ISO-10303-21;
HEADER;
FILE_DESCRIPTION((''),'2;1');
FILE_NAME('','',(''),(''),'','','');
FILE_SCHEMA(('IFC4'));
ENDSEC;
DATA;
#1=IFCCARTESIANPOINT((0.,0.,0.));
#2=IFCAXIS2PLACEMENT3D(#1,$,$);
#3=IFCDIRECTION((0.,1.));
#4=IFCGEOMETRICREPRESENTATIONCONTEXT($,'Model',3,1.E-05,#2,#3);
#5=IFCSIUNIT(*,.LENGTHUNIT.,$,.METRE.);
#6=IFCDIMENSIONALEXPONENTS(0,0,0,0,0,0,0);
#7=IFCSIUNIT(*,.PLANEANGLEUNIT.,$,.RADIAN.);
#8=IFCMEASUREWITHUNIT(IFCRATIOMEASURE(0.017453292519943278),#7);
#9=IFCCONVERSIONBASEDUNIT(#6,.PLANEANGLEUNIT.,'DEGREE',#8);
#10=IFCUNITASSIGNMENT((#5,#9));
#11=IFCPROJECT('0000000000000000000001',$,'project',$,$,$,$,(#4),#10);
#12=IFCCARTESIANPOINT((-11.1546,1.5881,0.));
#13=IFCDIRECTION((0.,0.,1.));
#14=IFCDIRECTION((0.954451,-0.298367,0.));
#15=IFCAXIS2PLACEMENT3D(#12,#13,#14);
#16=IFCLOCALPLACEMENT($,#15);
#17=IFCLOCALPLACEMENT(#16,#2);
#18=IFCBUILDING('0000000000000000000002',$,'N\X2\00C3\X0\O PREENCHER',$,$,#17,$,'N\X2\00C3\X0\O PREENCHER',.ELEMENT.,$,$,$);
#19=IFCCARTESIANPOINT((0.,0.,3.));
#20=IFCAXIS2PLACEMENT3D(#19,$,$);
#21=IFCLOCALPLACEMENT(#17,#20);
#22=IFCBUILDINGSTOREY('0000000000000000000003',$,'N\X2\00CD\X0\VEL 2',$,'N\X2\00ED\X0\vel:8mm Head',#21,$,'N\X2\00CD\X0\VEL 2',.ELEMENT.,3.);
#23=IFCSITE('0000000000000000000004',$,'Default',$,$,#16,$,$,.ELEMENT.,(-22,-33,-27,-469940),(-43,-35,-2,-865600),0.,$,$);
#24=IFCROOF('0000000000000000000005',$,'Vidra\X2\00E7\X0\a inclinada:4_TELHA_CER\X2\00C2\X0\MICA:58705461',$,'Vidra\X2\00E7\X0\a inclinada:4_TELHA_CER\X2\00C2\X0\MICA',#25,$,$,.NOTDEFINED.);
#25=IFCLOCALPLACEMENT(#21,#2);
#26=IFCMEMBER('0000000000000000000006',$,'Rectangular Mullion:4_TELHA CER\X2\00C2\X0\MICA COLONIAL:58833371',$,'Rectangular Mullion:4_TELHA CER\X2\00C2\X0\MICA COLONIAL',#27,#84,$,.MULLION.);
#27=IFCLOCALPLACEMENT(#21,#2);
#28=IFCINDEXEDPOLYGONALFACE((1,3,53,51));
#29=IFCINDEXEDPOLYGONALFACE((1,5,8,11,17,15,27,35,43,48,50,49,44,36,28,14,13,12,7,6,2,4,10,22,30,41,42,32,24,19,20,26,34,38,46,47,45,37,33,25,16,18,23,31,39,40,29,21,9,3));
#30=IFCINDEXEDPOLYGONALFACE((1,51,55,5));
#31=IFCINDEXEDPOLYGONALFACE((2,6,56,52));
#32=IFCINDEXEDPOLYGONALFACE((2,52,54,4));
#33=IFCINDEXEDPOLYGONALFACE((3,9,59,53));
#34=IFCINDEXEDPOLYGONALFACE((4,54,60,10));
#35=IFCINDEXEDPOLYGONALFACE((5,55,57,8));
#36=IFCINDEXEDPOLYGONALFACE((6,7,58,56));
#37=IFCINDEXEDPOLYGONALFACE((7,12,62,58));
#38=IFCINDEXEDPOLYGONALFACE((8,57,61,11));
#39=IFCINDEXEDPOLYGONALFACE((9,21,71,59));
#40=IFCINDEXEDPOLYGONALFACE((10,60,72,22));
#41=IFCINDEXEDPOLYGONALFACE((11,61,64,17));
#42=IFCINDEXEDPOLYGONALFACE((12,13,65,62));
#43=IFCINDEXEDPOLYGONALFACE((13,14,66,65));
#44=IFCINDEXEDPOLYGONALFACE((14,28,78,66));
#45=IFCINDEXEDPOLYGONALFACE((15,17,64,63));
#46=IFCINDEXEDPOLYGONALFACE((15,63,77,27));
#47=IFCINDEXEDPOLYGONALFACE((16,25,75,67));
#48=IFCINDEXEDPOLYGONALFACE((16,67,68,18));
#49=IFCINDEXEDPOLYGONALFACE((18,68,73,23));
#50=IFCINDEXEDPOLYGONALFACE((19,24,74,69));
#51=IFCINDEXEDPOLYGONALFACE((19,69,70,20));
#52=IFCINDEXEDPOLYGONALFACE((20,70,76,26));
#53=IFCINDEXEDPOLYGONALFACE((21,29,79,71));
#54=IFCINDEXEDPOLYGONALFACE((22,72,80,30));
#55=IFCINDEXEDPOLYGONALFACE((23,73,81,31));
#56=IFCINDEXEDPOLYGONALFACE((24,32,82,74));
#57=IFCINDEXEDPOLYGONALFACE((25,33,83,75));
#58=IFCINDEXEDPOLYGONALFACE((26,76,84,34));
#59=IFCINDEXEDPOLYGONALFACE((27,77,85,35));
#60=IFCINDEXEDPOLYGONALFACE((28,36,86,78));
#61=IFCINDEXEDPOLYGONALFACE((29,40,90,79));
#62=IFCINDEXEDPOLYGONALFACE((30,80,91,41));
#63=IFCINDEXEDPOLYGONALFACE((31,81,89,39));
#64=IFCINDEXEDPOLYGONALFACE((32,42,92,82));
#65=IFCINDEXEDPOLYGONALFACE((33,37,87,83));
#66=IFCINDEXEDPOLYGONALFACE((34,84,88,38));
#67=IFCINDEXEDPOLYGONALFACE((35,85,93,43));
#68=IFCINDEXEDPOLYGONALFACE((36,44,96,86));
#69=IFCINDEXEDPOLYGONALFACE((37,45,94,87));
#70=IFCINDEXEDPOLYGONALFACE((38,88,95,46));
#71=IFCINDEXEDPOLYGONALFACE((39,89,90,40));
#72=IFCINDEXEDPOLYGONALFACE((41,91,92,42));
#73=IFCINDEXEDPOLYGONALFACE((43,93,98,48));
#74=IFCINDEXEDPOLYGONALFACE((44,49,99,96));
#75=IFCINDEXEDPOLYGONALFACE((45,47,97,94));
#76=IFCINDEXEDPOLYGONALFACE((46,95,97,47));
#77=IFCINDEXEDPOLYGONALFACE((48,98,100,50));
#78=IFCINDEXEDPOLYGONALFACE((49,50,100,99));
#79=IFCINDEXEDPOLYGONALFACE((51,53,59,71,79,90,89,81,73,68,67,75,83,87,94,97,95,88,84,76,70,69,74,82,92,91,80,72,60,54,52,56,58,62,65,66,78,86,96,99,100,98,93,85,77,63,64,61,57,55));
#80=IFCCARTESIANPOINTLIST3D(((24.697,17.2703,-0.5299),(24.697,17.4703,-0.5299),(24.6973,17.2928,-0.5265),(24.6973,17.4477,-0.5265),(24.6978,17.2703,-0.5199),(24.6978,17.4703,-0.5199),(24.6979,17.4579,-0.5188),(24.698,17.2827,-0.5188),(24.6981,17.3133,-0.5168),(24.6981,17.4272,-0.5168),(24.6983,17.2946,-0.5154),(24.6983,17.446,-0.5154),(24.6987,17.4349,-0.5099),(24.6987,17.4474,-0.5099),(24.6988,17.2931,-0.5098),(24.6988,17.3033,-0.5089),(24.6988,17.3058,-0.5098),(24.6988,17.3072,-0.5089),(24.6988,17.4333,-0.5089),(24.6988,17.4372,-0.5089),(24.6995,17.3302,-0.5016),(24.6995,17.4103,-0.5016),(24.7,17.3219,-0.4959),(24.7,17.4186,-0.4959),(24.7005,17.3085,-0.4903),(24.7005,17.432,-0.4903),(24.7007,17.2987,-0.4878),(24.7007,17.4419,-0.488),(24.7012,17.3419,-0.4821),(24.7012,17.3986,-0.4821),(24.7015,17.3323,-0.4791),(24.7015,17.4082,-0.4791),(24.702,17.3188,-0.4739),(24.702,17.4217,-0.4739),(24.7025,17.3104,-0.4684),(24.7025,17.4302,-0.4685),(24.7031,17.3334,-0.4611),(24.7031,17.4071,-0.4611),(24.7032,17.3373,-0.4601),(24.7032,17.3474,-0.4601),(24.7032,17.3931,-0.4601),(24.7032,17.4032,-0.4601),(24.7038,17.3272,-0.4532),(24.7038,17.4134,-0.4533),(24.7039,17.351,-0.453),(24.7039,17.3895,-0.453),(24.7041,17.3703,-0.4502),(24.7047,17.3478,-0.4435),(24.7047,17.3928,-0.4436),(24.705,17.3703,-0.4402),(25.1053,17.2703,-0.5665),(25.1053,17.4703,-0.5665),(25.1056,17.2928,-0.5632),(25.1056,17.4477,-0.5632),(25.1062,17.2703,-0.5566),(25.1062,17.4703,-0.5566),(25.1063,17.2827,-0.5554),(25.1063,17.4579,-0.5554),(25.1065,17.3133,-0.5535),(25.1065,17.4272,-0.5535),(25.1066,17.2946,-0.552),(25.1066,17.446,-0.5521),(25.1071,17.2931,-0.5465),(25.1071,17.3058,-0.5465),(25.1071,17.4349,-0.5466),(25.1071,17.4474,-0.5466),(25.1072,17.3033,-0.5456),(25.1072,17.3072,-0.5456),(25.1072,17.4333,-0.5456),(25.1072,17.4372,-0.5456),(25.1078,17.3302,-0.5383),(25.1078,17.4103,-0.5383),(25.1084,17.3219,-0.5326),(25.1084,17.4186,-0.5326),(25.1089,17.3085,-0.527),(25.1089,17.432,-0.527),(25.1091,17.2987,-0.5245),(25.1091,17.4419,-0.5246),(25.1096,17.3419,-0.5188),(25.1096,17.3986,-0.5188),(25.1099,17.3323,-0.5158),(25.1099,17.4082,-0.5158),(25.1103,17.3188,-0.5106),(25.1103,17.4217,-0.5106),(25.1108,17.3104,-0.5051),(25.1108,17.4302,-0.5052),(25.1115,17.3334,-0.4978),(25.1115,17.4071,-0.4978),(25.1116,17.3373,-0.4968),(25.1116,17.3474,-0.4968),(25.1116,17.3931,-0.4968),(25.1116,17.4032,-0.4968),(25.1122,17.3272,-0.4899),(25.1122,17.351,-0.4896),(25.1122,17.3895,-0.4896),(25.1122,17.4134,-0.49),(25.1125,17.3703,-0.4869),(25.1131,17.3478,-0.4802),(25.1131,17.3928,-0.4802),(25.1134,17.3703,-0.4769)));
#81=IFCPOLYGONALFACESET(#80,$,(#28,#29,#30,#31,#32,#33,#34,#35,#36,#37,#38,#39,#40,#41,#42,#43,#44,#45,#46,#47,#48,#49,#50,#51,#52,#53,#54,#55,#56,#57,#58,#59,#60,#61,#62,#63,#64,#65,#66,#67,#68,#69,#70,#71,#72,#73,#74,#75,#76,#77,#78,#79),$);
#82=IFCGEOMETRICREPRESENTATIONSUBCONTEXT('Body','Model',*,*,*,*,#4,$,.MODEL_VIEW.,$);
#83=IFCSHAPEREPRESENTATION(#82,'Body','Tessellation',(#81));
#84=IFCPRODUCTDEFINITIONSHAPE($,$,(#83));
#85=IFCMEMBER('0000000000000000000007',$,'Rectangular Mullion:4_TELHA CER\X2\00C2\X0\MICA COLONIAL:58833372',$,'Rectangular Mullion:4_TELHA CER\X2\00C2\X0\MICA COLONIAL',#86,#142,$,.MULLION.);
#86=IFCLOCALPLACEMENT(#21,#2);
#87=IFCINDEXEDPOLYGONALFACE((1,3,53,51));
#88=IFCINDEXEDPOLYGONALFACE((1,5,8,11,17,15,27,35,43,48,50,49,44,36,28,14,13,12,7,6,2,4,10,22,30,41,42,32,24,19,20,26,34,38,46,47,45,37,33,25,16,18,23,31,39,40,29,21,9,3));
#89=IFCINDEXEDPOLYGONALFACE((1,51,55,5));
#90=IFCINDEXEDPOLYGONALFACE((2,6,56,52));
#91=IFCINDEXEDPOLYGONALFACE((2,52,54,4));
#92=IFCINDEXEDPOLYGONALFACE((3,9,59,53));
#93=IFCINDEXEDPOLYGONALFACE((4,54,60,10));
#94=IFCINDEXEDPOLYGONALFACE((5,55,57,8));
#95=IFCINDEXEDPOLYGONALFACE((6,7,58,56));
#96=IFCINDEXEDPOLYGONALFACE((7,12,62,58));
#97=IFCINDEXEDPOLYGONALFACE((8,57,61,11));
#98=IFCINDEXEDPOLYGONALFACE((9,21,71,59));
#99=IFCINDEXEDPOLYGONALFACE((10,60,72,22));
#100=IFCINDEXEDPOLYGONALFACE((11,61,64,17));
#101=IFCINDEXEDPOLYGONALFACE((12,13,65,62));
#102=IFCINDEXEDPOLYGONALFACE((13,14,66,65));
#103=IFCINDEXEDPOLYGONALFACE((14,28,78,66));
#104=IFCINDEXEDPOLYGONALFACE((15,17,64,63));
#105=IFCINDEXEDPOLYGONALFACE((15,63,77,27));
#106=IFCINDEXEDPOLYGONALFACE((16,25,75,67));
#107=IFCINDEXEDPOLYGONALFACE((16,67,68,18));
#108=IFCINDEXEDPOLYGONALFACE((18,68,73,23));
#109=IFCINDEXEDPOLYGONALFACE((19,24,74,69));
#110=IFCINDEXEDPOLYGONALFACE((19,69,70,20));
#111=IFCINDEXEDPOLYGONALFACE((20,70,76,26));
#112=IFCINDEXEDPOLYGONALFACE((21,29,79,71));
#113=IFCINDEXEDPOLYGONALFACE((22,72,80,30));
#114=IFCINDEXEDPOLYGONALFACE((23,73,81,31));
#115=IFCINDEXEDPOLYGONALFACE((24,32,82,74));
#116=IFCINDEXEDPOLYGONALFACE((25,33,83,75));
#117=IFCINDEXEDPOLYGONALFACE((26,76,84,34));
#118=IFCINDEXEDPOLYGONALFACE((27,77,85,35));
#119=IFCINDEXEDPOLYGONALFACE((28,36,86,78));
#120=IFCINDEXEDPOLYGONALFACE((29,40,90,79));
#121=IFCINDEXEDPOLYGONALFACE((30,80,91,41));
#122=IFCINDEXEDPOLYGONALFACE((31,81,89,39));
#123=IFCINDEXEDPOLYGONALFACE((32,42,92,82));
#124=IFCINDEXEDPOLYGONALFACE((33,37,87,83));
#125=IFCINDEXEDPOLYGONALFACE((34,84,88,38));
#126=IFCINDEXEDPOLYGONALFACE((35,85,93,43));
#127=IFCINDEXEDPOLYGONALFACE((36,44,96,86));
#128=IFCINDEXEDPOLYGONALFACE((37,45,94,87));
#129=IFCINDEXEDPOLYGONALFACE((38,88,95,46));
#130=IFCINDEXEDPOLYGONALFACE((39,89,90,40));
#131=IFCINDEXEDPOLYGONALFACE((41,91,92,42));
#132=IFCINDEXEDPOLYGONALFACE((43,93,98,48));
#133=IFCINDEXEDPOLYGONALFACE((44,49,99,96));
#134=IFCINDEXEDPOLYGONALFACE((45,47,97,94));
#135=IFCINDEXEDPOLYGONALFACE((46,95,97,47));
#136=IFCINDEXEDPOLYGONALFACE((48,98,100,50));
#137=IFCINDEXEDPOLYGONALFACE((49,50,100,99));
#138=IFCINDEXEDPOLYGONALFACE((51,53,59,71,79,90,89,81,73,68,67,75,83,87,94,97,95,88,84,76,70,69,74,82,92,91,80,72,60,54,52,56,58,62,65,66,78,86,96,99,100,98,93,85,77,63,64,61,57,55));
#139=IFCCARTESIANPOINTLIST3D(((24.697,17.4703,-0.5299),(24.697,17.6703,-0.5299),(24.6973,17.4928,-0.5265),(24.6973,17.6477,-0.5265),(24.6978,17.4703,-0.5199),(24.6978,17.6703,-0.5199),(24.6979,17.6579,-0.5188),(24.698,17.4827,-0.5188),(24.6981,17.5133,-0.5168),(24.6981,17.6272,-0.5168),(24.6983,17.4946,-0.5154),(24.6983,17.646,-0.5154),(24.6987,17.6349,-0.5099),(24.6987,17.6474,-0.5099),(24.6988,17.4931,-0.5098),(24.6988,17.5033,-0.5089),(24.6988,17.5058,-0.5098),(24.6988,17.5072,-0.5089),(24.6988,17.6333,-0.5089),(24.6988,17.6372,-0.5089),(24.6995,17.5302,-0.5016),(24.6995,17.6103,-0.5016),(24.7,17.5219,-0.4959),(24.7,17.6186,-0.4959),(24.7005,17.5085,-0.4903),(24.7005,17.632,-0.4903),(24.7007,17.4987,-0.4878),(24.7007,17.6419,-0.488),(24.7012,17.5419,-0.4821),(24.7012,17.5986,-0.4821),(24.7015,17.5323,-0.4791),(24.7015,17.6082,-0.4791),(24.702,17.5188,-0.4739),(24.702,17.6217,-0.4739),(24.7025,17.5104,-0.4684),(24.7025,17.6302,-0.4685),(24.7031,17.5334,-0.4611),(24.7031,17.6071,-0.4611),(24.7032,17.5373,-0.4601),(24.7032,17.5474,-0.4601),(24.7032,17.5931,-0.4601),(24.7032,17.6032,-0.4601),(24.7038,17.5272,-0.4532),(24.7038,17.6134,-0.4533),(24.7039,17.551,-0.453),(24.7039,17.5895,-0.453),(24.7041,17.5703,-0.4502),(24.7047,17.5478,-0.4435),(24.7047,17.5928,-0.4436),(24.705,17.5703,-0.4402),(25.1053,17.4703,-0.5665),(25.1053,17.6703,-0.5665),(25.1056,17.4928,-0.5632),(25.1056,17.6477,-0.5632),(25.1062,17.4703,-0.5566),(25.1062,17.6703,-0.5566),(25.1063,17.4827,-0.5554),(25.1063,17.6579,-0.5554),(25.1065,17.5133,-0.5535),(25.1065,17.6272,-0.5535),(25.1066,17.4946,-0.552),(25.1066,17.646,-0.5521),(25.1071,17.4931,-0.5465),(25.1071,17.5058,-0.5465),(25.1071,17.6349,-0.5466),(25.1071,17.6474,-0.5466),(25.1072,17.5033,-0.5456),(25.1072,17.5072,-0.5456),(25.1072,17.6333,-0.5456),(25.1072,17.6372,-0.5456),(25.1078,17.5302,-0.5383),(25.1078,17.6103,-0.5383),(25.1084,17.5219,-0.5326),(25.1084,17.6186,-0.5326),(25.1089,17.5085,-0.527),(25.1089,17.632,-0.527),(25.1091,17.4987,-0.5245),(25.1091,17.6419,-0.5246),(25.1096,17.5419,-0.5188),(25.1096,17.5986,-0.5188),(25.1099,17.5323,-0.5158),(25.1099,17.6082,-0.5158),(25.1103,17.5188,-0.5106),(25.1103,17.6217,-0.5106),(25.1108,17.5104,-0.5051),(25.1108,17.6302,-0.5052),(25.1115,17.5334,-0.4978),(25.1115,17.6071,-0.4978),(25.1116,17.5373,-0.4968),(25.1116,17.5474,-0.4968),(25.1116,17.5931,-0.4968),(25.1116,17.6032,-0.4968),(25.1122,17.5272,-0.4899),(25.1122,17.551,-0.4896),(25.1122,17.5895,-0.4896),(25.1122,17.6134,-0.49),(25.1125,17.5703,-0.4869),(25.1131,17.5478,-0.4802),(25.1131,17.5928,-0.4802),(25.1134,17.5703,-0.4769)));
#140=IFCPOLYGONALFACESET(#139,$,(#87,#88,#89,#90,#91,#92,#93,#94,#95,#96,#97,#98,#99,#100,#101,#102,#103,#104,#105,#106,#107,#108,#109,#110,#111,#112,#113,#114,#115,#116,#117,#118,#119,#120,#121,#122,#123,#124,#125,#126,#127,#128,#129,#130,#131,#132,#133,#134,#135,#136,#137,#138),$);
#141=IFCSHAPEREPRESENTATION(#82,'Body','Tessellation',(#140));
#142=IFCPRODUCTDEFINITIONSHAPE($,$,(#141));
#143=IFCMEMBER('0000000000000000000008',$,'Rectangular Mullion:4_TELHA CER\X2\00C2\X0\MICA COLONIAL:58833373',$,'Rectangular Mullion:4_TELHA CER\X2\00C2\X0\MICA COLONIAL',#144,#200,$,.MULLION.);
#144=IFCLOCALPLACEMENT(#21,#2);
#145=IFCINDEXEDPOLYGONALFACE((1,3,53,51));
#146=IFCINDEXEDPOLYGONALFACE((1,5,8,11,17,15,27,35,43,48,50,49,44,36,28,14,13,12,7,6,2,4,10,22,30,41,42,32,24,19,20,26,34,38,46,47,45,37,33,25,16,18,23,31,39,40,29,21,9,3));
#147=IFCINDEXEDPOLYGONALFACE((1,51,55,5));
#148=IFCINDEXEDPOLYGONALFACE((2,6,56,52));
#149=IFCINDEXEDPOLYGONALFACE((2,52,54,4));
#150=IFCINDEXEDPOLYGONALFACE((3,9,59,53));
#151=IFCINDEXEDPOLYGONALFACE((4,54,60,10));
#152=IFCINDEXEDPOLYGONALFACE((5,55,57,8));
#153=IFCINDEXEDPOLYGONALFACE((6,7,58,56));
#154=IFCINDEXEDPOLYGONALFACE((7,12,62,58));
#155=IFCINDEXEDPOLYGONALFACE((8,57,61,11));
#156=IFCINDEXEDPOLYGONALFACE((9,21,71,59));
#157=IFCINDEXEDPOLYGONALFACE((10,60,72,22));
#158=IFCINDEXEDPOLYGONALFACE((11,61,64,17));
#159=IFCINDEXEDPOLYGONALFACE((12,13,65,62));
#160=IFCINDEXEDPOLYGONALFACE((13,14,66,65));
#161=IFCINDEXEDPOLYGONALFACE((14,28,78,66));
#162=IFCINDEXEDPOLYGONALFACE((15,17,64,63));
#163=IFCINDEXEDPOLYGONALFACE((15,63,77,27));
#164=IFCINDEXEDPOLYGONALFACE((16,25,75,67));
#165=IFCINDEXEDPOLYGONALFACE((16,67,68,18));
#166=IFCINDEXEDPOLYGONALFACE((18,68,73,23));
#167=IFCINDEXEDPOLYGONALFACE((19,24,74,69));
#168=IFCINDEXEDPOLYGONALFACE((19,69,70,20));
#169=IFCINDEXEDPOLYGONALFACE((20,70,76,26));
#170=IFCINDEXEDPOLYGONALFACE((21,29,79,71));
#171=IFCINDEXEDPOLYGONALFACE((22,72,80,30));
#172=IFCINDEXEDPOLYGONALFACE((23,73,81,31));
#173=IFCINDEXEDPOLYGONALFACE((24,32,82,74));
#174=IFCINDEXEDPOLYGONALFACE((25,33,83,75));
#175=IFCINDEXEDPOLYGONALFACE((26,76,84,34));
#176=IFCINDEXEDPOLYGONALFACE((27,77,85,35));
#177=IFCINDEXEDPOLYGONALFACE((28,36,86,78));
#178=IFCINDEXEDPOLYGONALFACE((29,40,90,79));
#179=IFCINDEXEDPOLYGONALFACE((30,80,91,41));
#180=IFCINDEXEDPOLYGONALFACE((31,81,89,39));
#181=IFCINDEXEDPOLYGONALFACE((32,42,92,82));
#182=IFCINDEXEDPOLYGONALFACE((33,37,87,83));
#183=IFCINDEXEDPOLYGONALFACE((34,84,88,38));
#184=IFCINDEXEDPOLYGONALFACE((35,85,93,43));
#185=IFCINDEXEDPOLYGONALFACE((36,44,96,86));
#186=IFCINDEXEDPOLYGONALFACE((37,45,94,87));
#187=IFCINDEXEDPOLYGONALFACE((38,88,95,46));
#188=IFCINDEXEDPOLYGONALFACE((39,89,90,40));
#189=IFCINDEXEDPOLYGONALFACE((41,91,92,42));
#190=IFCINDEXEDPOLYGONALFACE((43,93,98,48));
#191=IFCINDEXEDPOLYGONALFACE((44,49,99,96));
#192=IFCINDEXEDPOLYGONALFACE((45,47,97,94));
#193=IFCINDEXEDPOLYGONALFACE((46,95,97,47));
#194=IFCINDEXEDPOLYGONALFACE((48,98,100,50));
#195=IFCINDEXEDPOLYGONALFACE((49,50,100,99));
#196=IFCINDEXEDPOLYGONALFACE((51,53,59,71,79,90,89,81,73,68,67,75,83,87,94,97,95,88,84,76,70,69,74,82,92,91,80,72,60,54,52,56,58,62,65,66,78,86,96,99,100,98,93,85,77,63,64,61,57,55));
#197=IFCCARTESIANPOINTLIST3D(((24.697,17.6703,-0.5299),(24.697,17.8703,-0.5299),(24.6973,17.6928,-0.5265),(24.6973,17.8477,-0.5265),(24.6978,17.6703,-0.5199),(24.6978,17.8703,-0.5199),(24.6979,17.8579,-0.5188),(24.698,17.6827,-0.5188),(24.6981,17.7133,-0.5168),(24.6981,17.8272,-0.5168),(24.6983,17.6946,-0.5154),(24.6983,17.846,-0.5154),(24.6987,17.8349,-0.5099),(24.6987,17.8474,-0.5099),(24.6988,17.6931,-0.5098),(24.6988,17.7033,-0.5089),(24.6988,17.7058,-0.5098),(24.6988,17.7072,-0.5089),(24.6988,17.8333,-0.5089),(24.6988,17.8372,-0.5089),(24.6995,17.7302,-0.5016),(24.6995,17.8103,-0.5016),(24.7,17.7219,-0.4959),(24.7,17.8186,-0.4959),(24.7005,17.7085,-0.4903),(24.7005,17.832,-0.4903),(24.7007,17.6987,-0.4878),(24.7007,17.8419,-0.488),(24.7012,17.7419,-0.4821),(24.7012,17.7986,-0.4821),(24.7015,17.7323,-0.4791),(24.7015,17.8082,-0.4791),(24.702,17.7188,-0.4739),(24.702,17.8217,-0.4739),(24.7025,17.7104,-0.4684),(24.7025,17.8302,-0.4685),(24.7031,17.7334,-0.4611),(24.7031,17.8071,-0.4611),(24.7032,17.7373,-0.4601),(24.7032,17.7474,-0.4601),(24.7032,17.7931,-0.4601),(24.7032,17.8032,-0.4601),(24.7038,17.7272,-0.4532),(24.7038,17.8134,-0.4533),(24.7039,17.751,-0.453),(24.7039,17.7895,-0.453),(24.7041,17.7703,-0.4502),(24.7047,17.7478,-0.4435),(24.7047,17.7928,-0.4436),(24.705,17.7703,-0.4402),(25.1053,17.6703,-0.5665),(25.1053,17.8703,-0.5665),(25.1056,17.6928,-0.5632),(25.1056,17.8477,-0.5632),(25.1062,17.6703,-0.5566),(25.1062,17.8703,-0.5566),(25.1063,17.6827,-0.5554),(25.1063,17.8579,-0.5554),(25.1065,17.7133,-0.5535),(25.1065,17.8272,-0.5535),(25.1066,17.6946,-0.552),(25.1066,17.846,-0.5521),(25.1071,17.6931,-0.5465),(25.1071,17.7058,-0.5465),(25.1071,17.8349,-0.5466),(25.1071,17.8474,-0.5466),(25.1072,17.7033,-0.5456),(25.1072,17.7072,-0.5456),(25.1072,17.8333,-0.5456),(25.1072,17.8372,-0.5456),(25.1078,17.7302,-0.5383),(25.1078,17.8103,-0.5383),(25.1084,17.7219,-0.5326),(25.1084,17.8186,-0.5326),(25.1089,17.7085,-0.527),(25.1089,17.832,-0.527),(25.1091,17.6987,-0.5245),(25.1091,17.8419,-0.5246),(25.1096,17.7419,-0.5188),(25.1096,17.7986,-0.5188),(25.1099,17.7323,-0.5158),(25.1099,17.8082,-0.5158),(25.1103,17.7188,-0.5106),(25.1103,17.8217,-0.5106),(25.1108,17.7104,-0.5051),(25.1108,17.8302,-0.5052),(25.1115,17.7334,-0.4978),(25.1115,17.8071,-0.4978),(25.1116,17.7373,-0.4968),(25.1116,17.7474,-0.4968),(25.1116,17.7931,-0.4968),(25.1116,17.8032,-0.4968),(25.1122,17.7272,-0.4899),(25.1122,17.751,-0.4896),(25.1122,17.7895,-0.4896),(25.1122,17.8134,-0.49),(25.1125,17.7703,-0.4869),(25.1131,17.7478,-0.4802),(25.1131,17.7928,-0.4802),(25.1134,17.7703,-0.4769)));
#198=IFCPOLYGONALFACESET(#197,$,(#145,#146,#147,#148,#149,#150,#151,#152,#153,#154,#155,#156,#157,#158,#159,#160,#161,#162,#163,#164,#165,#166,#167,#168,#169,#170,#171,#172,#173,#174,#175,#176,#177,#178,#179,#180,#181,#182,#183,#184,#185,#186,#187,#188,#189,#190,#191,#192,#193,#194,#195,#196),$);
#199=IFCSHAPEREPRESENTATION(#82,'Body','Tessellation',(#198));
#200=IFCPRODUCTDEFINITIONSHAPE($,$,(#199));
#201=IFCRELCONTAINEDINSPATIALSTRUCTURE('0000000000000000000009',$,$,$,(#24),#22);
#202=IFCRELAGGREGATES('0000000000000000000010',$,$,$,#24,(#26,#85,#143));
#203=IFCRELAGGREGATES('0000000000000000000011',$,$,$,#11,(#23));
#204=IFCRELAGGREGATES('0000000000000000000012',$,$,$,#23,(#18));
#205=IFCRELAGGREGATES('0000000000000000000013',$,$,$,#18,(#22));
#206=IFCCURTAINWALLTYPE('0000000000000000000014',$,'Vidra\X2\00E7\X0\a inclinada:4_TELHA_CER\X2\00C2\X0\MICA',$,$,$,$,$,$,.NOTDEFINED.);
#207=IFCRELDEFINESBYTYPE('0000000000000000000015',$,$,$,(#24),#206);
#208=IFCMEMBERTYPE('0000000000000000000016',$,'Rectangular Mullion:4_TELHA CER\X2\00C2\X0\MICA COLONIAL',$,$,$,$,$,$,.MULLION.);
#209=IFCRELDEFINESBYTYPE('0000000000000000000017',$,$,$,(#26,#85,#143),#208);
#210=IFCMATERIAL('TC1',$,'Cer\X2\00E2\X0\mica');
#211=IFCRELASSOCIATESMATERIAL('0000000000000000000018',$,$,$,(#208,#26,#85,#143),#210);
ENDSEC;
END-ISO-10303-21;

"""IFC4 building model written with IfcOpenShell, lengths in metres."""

from ifc_helpers import new_model, entity, si_unit, converted_unit, direction, frame, origin, place, context, subcontext, project, spatial, line, arc, indexed_curve, outline, extrude, source, transform, mapped, material, type_object, type_shapes, element, aggregate, save


model = new_model("IFC4")

# Units and contexts
model_context = context("Model", 3, precision=1e-05, world=origin(), true_north=direction((0.0, 1.0)))
body_context = subcontext(model_context, "Body", "Model", "MODEL_VIEW")
ifc_project = project(units=[si_unit("LENGTHUNIT", "METRE"), converted_unit("PLANEANGLEUNIT", "DEGREE", entity("IfcRatioMeasure", 0.017453292519943278), si_unit("PLANEANGLEUNIT", "RADIAN"), dimensions=[0, 0, 0, 0, 0, 0, 0])], contexts=[model_context])

# Site, building, storey
site_placement = place(None, frame((-11.1546, 1.5881, 0.0), z_axis=(0.0, 0.0, 1.0), x_axis=(0.954451, -0.298367, 0.0)))
site = spatial("IfcSite", under=ifc_project, at=site_placement, Name="Default", CompositionType="ELEMENT", RefLatitude=(-22, -33, -27, -469940), RefLongitude=(-43, -35, -2, -865600), RefElevation=0.0)
building_placement = place(site_placement, origin())
building = spatial("IfcBuilding", under=site, at=building_placement, Name="NÃO PREENCHER", LongName="NÃO PREENCHER", CompositionType="ELEMENT")
storey_placement = place(building_placement, frame((0.0, 0.0, 3.0)))
storey = spatial("IfcBuildingStorey", under=building, at=storey_placement, Name="NÍVEL 2", ObjectType="Nível:8mm Head", LongName="NÍVEL 2", CompositionType="ELEMENT", Elevation=3.0)

# Roof, members
curtain_wall_type = type_object("IfcCurtainWallType", Name="Vidraça inclinada:4_TELHA_CERÂMICA", PredefinedType="NOTDEFINED")
roof_placement = place(storey_placement, frame((0.0, 0.0, -3.0)))
roof = element("IfcRoof", 1, at=roof_placement, inside=storey, type_object=curtain_wall_type, Name="Vidraça inclinada:4_TELHA_CERÂMICA:58705461", ObjectType="Vidraça inclinada:4_TELHA_CERÂMICA", PredefinedType="NOTDEFINED")
ifc_material = material(Name="TC1", Category="Cerâmica")
member_type = type_object("IfcMemberType", Name="Rectangular Mullion:4_TELHA CERÂMICA COLONIAL", PredefinedType="MULLION", material=ifc_material)
shared_shape = source(origin(), body_context, "Body", "SweptSolid", [
    extrude(outline(indexed_curve([(-0.029, -0.1), (-0.019, -0.1), (-0.0164, -0.0815), (-0.0089, -0.0645), (-0.0089, -0.0771), (0.061, 0.0), (-0.009, 0.0771), (-0.009, 0.0646), (-0.0165, 0.0816), (-0.019, 0.1), (-0.029, 0.1), (-0.0089, 0.0479), (0.041, 0.0229), (0.041, 0.0329), (0.0131, 0.0425), (-0.008, 0.0631), (-0.008, 0.067), (0.051, 0.0), (-0.008, -0.067), (-0.008, -0.0631), (0.0131, -0.0425), (0.041, -0.0329), (0.041, -0.0229), (-0.0089, -0.0479)], segments=[line(1, 2), arc(2, 3, 4), line(4, 5), arc(5, 6, 7), line(7, 8), arc(8, 9, 10), line(10, 11), arc(11, 12, 13), line(13, 14), arc(14, 15, 16), line(16, 17), arc(17, 18, 19), line(19, 20), arc(20, 21, 22), line(22, 23), arc(23, 24, 1)], self_intersect=False)), frame((0.0, -0.029, -0.41), z_axis=(0.0, 0.0, 1.0), x_axis=(0.0, -1.0, 0.0)), (0.0, 0.0, 1.0), 0.41),
])
type_shapes(member_type, [shared_shape])
member_1_placement = place(roof_placement, frame((24.697, 17.3703, 2.4701), z_axis=(-0.99599, 0.0, 0.089469), x_axis=(0.0, 1.0, 0.0)))
member_1 = element("IfcMember", 2, at=member_1_placement, type_object=member_type, material=ifc_material, Name="Rectangular Mullion:4_TELHA CERÂMICA COLONIAL:58833371", ObjectType="Rectangular Mullion:4_TELHA CERÂMICA COLONIAL", PredefinedType="MULLION", context=body_context, shape_type="MappedRepresentation", body=[
    mapped(shared_shape, transform((0.0, 0.0, 0.0), scale=1.0)),
])
member_2_placement = place(roof_placement, frame((24.697, 17.5703, 2.4701), z_axis=(-0.99599, 0.0, 0.089469), x_axis=(0.0, 1.0, 0.0)))
member_2 = element("IfcMember", 3, at=member_2_placement, type_object=member_type, material=ifc_material, Name="Rectangular Mullion:4_TELHA CERÂMICA COLONIAL:58833372", ObjectType="Rectangular Mullion:4_TELHA CERÂMICA COLONIAL", PredefinedType="MULLION", context=body_context, shape_type="MappedRepresentation", body=[
    mapped(shared_shape, transform((0.0, 0.0, 0.0), scale=1.0)),
])
member_3_placement = place(roof_placement, frame((24.697, 17.7703, 2.4701), z_axis=(-0.99599, 0.0, 0.089469), x_axis=(0.0, 1.0, 0.0)))
member_3 = element("IfcMember", 4, at=member_3_placement, type_object=member_type, material=ifc_material, Name="Rectangular Mullion:4_TELHA CERÂMICA COLONIAL:58833373", ObjectType="Rectangular Mullion:4_TELHA CERÂMICA COLONIAL", PredefinedType="MULLION", context=body_context, shape_type="MappedRepresentation", body=[
    mapped(shared_shape, transform((0.0, 0.0, 0.0), scale=1.0)),
])
aggregate(roof, [member_1, member_2, member_3])

save(model, "model.ifc")
